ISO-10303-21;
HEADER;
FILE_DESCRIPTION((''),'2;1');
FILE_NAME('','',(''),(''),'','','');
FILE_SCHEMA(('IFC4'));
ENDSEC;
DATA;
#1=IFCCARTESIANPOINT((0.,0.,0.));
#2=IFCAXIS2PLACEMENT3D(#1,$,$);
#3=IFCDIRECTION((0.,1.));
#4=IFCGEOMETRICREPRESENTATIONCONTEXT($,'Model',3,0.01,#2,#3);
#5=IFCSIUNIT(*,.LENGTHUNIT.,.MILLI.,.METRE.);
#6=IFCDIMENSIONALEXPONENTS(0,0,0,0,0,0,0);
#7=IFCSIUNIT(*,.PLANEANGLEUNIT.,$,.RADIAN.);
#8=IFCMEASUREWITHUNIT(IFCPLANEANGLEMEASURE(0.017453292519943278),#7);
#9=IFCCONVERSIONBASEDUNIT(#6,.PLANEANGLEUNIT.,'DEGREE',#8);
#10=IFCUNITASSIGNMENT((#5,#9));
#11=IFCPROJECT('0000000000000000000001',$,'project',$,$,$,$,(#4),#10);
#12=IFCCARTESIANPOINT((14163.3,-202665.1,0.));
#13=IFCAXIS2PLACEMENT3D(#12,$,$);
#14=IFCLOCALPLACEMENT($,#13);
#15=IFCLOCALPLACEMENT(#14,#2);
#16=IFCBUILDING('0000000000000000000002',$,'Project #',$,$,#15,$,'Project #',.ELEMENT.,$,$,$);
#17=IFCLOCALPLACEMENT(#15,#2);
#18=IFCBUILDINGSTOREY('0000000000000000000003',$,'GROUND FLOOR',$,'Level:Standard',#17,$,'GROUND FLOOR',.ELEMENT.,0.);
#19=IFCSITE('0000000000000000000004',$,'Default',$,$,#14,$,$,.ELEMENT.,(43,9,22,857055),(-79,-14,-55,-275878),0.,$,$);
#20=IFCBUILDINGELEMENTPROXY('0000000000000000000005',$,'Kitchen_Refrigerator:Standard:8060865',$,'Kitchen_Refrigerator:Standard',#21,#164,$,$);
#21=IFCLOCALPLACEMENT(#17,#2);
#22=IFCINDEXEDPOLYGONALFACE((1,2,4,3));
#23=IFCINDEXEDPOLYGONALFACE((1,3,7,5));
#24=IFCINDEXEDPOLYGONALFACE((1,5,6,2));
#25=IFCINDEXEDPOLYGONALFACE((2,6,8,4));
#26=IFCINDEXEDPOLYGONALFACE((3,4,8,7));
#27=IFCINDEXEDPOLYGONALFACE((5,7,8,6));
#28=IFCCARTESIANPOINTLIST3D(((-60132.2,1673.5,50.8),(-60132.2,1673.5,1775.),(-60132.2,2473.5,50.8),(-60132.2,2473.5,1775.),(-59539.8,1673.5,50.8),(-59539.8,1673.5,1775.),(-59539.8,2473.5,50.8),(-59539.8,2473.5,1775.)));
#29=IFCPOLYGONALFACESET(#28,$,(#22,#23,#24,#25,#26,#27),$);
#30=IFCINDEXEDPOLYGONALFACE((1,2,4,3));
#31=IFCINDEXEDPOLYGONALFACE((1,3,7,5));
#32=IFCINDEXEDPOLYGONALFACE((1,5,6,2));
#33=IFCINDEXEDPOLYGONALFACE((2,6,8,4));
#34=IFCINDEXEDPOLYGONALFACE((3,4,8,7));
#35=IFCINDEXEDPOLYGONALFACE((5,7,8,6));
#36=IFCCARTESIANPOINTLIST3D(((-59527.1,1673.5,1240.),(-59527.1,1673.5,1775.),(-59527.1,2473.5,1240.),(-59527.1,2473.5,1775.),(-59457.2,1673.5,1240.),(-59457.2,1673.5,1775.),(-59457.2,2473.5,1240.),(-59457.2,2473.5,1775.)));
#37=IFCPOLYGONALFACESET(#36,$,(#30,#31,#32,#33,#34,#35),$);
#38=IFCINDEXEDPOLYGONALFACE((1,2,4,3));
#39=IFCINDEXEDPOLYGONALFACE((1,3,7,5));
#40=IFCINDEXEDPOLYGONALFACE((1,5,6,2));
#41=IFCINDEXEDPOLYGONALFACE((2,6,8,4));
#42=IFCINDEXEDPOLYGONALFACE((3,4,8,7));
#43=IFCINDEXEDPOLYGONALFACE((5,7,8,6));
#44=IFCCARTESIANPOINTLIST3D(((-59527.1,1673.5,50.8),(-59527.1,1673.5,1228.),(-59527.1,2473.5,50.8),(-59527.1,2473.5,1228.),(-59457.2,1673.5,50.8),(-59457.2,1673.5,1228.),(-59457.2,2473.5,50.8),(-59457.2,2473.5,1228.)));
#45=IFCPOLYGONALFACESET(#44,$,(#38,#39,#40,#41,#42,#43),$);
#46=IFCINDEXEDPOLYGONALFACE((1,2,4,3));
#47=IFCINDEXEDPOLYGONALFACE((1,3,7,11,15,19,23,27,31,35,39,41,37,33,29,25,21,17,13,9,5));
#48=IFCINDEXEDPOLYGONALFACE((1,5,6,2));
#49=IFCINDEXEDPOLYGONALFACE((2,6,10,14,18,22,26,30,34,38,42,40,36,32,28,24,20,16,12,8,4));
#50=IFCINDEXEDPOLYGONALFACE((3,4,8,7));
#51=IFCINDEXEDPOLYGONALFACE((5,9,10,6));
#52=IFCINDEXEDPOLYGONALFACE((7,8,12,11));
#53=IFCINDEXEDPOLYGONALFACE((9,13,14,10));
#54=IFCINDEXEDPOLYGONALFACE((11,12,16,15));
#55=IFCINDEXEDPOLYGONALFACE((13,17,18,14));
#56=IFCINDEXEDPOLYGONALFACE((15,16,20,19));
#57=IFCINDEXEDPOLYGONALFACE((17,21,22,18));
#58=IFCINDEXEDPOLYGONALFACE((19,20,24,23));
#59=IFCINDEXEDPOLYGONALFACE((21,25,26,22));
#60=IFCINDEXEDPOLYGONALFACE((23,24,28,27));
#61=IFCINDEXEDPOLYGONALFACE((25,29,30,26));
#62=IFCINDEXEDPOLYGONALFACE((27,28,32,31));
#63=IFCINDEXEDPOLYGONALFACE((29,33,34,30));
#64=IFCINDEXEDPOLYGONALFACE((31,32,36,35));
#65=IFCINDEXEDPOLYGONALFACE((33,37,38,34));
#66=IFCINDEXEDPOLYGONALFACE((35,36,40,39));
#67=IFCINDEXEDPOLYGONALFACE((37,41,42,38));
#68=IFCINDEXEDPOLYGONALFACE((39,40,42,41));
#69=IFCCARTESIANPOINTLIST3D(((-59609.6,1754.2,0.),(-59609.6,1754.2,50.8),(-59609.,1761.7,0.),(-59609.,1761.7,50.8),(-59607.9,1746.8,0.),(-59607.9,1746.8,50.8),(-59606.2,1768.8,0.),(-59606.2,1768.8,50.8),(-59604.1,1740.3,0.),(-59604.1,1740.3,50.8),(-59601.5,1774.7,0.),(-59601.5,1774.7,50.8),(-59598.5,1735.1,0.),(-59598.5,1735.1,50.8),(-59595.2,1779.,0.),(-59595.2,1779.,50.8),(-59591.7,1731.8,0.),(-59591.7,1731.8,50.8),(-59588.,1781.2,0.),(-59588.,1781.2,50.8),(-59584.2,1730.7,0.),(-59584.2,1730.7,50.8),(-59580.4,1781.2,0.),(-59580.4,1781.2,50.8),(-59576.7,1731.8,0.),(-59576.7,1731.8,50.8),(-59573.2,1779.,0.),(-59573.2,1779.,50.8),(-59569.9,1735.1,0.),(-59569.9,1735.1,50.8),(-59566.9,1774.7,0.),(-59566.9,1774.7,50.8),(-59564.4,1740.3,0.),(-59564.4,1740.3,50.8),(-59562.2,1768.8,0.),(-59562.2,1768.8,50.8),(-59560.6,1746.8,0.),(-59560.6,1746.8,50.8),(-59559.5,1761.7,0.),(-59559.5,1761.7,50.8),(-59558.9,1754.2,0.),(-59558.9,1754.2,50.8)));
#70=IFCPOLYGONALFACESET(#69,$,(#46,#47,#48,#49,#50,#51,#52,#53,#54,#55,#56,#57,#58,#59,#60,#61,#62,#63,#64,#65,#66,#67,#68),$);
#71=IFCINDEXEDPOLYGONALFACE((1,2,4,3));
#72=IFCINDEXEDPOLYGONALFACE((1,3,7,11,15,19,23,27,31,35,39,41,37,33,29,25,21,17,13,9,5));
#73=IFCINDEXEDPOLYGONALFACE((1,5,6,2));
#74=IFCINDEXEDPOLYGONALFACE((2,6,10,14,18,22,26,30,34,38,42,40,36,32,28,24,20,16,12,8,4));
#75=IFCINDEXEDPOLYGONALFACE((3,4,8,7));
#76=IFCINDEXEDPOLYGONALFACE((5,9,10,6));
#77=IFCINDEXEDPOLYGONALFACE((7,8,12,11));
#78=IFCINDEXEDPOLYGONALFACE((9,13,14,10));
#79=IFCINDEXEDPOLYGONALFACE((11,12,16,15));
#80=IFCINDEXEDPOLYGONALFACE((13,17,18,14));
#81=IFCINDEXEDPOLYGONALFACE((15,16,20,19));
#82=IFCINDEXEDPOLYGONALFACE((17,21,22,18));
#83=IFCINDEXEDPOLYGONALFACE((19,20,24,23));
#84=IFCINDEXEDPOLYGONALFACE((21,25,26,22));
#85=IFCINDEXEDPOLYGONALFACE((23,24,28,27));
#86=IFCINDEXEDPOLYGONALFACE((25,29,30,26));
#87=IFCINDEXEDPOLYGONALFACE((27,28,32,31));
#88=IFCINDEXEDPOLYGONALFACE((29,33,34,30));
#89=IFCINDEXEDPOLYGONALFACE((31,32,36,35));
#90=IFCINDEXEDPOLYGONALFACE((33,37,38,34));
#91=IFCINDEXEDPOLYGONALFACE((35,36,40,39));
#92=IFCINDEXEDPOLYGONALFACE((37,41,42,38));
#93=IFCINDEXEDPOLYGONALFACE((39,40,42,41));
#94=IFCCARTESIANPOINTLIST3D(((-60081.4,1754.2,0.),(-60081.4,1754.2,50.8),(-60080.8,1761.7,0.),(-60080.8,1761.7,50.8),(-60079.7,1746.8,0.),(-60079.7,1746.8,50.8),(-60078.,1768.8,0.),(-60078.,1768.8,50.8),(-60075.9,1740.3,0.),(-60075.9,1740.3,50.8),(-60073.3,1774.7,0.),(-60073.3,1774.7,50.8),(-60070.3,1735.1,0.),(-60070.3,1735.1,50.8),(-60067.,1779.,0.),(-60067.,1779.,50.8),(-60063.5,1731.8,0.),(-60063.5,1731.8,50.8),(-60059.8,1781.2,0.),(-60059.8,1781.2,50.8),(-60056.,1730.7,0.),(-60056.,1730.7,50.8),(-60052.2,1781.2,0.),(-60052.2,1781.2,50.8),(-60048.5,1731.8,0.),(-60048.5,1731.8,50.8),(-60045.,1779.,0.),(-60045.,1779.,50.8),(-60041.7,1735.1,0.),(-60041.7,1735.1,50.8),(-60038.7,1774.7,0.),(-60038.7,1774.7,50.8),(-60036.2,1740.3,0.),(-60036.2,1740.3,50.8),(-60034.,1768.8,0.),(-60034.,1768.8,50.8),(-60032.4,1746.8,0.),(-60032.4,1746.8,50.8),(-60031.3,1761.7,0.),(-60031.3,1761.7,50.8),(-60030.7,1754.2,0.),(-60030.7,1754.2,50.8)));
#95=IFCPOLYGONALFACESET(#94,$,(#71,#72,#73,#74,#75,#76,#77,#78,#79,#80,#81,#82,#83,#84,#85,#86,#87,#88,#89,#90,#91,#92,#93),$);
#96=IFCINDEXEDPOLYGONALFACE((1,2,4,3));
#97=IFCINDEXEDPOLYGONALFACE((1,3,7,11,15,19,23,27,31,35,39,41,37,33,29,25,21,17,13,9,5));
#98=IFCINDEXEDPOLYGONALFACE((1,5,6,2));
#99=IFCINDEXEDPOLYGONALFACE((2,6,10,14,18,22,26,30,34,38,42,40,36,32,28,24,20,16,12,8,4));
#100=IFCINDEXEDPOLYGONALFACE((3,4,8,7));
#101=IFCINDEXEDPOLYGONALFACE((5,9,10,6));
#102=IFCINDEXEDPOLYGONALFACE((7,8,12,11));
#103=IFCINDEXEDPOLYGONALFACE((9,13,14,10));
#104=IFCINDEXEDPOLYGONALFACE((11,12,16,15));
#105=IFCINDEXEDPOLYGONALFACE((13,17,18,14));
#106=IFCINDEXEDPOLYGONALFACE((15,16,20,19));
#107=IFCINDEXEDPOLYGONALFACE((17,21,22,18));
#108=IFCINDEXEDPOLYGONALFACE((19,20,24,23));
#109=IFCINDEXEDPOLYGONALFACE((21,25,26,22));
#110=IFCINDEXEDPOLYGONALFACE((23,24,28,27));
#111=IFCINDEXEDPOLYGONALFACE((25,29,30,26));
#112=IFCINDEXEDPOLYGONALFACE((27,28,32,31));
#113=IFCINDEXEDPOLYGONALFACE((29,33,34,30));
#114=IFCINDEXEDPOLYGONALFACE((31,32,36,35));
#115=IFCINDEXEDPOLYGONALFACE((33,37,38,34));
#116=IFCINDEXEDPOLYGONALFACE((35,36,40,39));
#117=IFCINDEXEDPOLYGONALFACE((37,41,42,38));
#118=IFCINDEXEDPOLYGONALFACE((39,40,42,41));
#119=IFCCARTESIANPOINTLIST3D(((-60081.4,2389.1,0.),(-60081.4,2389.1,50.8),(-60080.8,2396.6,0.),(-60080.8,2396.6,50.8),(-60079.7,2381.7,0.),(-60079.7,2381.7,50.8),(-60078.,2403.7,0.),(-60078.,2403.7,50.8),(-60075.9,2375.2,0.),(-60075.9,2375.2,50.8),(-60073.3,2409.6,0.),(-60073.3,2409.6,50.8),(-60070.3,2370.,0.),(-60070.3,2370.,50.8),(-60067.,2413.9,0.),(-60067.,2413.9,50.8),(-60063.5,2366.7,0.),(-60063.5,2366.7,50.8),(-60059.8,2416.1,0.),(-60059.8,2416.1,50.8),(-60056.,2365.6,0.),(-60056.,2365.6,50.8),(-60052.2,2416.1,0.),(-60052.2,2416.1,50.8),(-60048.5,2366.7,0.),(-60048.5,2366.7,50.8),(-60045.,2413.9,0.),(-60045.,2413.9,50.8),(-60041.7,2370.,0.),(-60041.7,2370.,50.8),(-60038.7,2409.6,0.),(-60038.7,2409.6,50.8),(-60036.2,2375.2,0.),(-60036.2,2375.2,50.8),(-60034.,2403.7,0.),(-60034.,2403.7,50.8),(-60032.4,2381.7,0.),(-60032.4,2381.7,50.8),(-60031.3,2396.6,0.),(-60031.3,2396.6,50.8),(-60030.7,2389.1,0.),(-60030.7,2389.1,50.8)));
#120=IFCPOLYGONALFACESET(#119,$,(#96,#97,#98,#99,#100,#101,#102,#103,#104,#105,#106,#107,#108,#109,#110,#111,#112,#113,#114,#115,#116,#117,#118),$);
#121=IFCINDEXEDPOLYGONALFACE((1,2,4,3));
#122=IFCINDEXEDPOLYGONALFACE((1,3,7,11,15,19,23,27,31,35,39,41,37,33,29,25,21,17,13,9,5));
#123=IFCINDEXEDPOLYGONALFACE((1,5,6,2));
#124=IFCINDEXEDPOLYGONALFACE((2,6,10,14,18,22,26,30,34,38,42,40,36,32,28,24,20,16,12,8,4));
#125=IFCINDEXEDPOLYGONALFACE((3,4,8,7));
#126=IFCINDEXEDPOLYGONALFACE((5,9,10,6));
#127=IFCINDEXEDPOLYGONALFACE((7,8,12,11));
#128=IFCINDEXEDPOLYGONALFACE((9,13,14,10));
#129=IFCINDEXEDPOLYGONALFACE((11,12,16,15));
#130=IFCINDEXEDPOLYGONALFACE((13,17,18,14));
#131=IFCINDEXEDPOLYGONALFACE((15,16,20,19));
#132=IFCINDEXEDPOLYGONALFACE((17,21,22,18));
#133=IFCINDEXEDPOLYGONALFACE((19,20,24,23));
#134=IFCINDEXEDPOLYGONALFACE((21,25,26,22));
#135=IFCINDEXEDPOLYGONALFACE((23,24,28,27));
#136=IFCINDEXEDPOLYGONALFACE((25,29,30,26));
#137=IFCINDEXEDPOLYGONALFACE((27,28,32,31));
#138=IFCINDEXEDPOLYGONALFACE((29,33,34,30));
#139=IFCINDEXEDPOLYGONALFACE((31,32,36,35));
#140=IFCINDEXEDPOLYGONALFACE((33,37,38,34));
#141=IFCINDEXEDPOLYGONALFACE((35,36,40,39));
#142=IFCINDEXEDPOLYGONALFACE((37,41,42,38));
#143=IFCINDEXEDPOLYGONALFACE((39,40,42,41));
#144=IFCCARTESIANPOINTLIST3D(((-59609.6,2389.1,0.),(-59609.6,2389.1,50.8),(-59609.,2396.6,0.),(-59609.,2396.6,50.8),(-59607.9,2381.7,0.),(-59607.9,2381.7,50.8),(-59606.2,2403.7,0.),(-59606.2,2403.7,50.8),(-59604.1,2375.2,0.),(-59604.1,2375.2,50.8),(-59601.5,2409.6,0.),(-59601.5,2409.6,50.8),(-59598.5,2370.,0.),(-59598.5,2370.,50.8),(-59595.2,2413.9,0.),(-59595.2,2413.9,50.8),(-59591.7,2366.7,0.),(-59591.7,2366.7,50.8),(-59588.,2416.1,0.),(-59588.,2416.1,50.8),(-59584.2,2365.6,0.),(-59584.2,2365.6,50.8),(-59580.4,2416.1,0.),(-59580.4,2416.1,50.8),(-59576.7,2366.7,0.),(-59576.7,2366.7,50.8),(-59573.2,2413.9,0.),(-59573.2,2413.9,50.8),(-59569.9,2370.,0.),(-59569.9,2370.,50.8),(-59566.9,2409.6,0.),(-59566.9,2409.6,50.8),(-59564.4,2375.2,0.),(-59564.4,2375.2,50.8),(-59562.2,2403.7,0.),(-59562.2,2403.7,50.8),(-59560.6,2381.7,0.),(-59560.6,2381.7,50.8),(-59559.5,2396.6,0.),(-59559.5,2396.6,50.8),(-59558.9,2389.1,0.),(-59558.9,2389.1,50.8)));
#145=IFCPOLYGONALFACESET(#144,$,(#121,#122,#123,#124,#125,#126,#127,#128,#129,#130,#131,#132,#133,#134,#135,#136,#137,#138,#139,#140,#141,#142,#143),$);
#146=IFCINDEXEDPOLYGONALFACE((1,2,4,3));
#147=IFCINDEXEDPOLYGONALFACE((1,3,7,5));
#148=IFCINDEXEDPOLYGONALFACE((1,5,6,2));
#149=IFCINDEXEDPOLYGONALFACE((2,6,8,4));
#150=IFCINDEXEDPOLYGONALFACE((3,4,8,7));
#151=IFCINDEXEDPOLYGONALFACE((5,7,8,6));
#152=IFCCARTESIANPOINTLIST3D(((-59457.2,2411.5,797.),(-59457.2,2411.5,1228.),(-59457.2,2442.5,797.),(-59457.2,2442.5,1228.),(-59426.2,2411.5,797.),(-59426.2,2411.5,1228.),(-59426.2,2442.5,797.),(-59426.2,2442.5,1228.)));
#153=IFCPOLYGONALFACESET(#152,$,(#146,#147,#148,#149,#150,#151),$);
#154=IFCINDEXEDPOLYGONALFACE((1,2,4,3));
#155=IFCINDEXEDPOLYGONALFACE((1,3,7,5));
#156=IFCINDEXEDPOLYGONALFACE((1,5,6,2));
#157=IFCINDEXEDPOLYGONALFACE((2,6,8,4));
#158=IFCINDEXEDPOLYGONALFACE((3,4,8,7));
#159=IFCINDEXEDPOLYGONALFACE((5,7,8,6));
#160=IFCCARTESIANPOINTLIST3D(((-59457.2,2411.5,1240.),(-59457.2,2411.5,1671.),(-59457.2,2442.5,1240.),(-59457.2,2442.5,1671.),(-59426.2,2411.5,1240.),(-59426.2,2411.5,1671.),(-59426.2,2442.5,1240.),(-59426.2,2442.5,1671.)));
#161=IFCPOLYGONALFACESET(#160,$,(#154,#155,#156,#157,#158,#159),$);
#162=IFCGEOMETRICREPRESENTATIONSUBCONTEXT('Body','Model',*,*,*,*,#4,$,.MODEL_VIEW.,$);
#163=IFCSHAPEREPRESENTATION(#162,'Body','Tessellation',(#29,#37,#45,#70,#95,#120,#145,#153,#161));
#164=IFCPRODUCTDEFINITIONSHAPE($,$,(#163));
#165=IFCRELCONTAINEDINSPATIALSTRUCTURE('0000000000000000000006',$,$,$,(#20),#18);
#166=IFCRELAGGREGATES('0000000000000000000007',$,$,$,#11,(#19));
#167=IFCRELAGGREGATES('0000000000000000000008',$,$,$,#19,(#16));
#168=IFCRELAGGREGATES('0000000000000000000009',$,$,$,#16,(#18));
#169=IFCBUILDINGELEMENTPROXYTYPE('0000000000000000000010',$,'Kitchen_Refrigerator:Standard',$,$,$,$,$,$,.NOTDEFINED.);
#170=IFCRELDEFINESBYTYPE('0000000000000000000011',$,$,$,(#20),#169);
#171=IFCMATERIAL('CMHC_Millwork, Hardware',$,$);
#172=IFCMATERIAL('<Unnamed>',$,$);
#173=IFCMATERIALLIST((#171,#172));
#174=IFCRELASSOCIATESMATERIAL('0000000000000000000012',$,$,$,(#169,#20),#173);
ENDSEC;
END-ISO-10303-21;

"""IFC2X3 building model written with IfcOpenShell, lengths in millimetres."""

from ifc_helpers import new_model, entity, si_unit, converted_unit, direction, frame, frame_2d, origin, place, context, subcontext, project, spatial, rectangle, circle, extrude, source, transform, mapped, material, material_list, type_object, type_shapes, element, save


model = new_model("IFC2X3")

# Units and contexts
model_context = context("Model", 3, precision=0.01, world=origin(), true_north=direction((0.0, 1.0)))
body_context = subcontext(model_context, "Body", "Model", "MODEL_VIEW")
ifc_project = project(units=[si_unit("LENGTHUNIT", "METRE", prefix="MILLI"), converted_unit("PLANEANGLEUNIT", "DEGREE", entity("IfcPlaneAngleMeasure", 0.017453292519943278), si_unit("PLANEANGLEUNIT", "RADIAN"), dimensions=[0, 0, 0, 0, 0, 0, 0])], contexts=[model_context])

# Site, building, storey
site_placement = place(None, frame((14163.3, -202665.1, 0.0)))
site = spatial("IfcSite", under=ifc_project, at=site_placement, Name="Default", CompositionType="ELEMENT", RefLatitude=(43, 9, 22, 857055), RefLongitude=(-79, -14, -55, -275878), RefElevation=0.0)
building_placement = place(site_placement, origin())
building = spatial("IfcBuilding", under=site, at=building_placement, Name="Project #", LongName="Project #", CompositionType="ELEMENT")
storey_placement = place(building_placement, origin())
storey = spatial("IfcBuildingStorey", under=building, at=storey_placement, Name="GROUND FLOOR", ObjectType="Level:Standard", LongName="GROUND FLOOR", CompositionType="ELEMENT", Elevation=0.0)

# Building element proxy
ifc_material_1 = material(Name="CMHC_Millwork, Hardware")
ifc_material_2 = material(Name="<Unnamed>")
ifc_material_list = material_list([ifc_material_1, ifc_material_2])
building_element_proxy_type_1 = type_object("IfcBuildingElementProxyType", Name="Kitchen_Refrigerator:Standard", PredefinedType="NOTDEFINED", material=ifc_material_list)
shared_shape_1 = source(origin(), body_context, "Body", "SweptSolid", [
    extrude(rectangle(XDim=800.0, YDim=592.5, at=frame_2d((0.0, 0.0), x_axis=(1.0, 0.0))), frame((-53.8, -7.5, 50.8), z_axis=(0.0, 0.0, 1.0), x_axis=(-1.0, 0.0, 0.0)), (0.0, 0.0, 1.0), 1724.2),
    extrude(rectangle(XDim=800.0, YDim=69.9, at=frame_2d((0.0, 0.0), x_axis=(1.0, 0.0))), frame((-53.8, 336.4, 1240.0), z_axis=(0.0, 0.0, 1.0), x_axis=(-1.0, 0.0, 0.0)), (0.0, 0.0, 1.0), 535.0),
    extrude(rectangle(XDim=800.0, YDim=69.9, at=frame_2d((0.0, 0.0), x_axis=(1.0, 0.0))), frame((-53.8, 336.4, 50.8), z_axis=(0.0, 0.0, 1.0), x_axis=(-1.0, 0.0, 0.0)), (0.0, 0.0, 1.0), 1177.2),
    extrude(circle(Radius=25.4, at=frame_2d((0.0, 0.0), x_axis=(1.0, 0.0))), frame((263.6, 244.3, 0.0)), (0.0, 0.0, 1.0), 50.8),
    extrude(circle(Radius=25.4, at=frame_2d((0.0, 0.0), x_axis=(1.0, 0.0))), frame((263.6, -227.5, 0.0)), (0.0, 0.0, 1.0), 50.8),
    extrude(circle(Radius=25.4, at=frame_2d((0.0, 0.0), x_axis=(1.0, 0.0))), frame((-371.3, -227.5, 0.0)), (0.0, 0.0, 1.0), 50.8),
    extrude(circle(Radius=25.4, at=frame_2d((0.0, 0.0), x_axis=(1.0, 0.0))), frame((-371.3, 244.3, 0.0)), (0.0, 0.0, 1.0), 50.8),
    extrude(rectangle(XDim=31.0, YDim=31.0, at=frame_2d((0.0, 0.0), x_axis=(1.0, 0.0))), frame((-407.3, 386.8, 797.0), z_axis=(0.0, 0.0, 1.0), x_axis=(-1.0, 0.0, 0.0)), (0.0, 0.0, 1.0), 431.0),
    extrude(rectangle(XDim=31.0, YDim=31.0, at=frame_2d((0.0, 0.0), x_axis=(1.0, 0.0))), frame((-407.3, 386.8, 1240.0), z_axis=(0.0, 0.0, 1.0), x_axis=(-1.0, 0.0, 0.0)), (0.0, 0.0, 1.0), 431.0),
])
type_shapes(building_element_proxy_type_1, [shared_shape_1])
proxy_1_placement = place(storey_placement, frame((-59828.5, 2019.7, 0.0), z_axis=(0.0, 0.0, 1.0), x_axis=(0.0, -1.0, 0.0)))
element("IfcBuildingElementProxy", 1, at=proxy_1_placement, inside=storey, type_object=building_element_proxy_type_1, material=ifc_material_list, Name="Kitchen_Refrigerator:Standard:8060865", ObjectType="Kitchen_Refrigerator:Standard", context=body_context, shape_type="MappedRepresentation", body=[
    mapped(shared_shape_1, transform((0.0, 0.0, 0.0), scale=1.0)),
])

save(model, "model.ifc")
